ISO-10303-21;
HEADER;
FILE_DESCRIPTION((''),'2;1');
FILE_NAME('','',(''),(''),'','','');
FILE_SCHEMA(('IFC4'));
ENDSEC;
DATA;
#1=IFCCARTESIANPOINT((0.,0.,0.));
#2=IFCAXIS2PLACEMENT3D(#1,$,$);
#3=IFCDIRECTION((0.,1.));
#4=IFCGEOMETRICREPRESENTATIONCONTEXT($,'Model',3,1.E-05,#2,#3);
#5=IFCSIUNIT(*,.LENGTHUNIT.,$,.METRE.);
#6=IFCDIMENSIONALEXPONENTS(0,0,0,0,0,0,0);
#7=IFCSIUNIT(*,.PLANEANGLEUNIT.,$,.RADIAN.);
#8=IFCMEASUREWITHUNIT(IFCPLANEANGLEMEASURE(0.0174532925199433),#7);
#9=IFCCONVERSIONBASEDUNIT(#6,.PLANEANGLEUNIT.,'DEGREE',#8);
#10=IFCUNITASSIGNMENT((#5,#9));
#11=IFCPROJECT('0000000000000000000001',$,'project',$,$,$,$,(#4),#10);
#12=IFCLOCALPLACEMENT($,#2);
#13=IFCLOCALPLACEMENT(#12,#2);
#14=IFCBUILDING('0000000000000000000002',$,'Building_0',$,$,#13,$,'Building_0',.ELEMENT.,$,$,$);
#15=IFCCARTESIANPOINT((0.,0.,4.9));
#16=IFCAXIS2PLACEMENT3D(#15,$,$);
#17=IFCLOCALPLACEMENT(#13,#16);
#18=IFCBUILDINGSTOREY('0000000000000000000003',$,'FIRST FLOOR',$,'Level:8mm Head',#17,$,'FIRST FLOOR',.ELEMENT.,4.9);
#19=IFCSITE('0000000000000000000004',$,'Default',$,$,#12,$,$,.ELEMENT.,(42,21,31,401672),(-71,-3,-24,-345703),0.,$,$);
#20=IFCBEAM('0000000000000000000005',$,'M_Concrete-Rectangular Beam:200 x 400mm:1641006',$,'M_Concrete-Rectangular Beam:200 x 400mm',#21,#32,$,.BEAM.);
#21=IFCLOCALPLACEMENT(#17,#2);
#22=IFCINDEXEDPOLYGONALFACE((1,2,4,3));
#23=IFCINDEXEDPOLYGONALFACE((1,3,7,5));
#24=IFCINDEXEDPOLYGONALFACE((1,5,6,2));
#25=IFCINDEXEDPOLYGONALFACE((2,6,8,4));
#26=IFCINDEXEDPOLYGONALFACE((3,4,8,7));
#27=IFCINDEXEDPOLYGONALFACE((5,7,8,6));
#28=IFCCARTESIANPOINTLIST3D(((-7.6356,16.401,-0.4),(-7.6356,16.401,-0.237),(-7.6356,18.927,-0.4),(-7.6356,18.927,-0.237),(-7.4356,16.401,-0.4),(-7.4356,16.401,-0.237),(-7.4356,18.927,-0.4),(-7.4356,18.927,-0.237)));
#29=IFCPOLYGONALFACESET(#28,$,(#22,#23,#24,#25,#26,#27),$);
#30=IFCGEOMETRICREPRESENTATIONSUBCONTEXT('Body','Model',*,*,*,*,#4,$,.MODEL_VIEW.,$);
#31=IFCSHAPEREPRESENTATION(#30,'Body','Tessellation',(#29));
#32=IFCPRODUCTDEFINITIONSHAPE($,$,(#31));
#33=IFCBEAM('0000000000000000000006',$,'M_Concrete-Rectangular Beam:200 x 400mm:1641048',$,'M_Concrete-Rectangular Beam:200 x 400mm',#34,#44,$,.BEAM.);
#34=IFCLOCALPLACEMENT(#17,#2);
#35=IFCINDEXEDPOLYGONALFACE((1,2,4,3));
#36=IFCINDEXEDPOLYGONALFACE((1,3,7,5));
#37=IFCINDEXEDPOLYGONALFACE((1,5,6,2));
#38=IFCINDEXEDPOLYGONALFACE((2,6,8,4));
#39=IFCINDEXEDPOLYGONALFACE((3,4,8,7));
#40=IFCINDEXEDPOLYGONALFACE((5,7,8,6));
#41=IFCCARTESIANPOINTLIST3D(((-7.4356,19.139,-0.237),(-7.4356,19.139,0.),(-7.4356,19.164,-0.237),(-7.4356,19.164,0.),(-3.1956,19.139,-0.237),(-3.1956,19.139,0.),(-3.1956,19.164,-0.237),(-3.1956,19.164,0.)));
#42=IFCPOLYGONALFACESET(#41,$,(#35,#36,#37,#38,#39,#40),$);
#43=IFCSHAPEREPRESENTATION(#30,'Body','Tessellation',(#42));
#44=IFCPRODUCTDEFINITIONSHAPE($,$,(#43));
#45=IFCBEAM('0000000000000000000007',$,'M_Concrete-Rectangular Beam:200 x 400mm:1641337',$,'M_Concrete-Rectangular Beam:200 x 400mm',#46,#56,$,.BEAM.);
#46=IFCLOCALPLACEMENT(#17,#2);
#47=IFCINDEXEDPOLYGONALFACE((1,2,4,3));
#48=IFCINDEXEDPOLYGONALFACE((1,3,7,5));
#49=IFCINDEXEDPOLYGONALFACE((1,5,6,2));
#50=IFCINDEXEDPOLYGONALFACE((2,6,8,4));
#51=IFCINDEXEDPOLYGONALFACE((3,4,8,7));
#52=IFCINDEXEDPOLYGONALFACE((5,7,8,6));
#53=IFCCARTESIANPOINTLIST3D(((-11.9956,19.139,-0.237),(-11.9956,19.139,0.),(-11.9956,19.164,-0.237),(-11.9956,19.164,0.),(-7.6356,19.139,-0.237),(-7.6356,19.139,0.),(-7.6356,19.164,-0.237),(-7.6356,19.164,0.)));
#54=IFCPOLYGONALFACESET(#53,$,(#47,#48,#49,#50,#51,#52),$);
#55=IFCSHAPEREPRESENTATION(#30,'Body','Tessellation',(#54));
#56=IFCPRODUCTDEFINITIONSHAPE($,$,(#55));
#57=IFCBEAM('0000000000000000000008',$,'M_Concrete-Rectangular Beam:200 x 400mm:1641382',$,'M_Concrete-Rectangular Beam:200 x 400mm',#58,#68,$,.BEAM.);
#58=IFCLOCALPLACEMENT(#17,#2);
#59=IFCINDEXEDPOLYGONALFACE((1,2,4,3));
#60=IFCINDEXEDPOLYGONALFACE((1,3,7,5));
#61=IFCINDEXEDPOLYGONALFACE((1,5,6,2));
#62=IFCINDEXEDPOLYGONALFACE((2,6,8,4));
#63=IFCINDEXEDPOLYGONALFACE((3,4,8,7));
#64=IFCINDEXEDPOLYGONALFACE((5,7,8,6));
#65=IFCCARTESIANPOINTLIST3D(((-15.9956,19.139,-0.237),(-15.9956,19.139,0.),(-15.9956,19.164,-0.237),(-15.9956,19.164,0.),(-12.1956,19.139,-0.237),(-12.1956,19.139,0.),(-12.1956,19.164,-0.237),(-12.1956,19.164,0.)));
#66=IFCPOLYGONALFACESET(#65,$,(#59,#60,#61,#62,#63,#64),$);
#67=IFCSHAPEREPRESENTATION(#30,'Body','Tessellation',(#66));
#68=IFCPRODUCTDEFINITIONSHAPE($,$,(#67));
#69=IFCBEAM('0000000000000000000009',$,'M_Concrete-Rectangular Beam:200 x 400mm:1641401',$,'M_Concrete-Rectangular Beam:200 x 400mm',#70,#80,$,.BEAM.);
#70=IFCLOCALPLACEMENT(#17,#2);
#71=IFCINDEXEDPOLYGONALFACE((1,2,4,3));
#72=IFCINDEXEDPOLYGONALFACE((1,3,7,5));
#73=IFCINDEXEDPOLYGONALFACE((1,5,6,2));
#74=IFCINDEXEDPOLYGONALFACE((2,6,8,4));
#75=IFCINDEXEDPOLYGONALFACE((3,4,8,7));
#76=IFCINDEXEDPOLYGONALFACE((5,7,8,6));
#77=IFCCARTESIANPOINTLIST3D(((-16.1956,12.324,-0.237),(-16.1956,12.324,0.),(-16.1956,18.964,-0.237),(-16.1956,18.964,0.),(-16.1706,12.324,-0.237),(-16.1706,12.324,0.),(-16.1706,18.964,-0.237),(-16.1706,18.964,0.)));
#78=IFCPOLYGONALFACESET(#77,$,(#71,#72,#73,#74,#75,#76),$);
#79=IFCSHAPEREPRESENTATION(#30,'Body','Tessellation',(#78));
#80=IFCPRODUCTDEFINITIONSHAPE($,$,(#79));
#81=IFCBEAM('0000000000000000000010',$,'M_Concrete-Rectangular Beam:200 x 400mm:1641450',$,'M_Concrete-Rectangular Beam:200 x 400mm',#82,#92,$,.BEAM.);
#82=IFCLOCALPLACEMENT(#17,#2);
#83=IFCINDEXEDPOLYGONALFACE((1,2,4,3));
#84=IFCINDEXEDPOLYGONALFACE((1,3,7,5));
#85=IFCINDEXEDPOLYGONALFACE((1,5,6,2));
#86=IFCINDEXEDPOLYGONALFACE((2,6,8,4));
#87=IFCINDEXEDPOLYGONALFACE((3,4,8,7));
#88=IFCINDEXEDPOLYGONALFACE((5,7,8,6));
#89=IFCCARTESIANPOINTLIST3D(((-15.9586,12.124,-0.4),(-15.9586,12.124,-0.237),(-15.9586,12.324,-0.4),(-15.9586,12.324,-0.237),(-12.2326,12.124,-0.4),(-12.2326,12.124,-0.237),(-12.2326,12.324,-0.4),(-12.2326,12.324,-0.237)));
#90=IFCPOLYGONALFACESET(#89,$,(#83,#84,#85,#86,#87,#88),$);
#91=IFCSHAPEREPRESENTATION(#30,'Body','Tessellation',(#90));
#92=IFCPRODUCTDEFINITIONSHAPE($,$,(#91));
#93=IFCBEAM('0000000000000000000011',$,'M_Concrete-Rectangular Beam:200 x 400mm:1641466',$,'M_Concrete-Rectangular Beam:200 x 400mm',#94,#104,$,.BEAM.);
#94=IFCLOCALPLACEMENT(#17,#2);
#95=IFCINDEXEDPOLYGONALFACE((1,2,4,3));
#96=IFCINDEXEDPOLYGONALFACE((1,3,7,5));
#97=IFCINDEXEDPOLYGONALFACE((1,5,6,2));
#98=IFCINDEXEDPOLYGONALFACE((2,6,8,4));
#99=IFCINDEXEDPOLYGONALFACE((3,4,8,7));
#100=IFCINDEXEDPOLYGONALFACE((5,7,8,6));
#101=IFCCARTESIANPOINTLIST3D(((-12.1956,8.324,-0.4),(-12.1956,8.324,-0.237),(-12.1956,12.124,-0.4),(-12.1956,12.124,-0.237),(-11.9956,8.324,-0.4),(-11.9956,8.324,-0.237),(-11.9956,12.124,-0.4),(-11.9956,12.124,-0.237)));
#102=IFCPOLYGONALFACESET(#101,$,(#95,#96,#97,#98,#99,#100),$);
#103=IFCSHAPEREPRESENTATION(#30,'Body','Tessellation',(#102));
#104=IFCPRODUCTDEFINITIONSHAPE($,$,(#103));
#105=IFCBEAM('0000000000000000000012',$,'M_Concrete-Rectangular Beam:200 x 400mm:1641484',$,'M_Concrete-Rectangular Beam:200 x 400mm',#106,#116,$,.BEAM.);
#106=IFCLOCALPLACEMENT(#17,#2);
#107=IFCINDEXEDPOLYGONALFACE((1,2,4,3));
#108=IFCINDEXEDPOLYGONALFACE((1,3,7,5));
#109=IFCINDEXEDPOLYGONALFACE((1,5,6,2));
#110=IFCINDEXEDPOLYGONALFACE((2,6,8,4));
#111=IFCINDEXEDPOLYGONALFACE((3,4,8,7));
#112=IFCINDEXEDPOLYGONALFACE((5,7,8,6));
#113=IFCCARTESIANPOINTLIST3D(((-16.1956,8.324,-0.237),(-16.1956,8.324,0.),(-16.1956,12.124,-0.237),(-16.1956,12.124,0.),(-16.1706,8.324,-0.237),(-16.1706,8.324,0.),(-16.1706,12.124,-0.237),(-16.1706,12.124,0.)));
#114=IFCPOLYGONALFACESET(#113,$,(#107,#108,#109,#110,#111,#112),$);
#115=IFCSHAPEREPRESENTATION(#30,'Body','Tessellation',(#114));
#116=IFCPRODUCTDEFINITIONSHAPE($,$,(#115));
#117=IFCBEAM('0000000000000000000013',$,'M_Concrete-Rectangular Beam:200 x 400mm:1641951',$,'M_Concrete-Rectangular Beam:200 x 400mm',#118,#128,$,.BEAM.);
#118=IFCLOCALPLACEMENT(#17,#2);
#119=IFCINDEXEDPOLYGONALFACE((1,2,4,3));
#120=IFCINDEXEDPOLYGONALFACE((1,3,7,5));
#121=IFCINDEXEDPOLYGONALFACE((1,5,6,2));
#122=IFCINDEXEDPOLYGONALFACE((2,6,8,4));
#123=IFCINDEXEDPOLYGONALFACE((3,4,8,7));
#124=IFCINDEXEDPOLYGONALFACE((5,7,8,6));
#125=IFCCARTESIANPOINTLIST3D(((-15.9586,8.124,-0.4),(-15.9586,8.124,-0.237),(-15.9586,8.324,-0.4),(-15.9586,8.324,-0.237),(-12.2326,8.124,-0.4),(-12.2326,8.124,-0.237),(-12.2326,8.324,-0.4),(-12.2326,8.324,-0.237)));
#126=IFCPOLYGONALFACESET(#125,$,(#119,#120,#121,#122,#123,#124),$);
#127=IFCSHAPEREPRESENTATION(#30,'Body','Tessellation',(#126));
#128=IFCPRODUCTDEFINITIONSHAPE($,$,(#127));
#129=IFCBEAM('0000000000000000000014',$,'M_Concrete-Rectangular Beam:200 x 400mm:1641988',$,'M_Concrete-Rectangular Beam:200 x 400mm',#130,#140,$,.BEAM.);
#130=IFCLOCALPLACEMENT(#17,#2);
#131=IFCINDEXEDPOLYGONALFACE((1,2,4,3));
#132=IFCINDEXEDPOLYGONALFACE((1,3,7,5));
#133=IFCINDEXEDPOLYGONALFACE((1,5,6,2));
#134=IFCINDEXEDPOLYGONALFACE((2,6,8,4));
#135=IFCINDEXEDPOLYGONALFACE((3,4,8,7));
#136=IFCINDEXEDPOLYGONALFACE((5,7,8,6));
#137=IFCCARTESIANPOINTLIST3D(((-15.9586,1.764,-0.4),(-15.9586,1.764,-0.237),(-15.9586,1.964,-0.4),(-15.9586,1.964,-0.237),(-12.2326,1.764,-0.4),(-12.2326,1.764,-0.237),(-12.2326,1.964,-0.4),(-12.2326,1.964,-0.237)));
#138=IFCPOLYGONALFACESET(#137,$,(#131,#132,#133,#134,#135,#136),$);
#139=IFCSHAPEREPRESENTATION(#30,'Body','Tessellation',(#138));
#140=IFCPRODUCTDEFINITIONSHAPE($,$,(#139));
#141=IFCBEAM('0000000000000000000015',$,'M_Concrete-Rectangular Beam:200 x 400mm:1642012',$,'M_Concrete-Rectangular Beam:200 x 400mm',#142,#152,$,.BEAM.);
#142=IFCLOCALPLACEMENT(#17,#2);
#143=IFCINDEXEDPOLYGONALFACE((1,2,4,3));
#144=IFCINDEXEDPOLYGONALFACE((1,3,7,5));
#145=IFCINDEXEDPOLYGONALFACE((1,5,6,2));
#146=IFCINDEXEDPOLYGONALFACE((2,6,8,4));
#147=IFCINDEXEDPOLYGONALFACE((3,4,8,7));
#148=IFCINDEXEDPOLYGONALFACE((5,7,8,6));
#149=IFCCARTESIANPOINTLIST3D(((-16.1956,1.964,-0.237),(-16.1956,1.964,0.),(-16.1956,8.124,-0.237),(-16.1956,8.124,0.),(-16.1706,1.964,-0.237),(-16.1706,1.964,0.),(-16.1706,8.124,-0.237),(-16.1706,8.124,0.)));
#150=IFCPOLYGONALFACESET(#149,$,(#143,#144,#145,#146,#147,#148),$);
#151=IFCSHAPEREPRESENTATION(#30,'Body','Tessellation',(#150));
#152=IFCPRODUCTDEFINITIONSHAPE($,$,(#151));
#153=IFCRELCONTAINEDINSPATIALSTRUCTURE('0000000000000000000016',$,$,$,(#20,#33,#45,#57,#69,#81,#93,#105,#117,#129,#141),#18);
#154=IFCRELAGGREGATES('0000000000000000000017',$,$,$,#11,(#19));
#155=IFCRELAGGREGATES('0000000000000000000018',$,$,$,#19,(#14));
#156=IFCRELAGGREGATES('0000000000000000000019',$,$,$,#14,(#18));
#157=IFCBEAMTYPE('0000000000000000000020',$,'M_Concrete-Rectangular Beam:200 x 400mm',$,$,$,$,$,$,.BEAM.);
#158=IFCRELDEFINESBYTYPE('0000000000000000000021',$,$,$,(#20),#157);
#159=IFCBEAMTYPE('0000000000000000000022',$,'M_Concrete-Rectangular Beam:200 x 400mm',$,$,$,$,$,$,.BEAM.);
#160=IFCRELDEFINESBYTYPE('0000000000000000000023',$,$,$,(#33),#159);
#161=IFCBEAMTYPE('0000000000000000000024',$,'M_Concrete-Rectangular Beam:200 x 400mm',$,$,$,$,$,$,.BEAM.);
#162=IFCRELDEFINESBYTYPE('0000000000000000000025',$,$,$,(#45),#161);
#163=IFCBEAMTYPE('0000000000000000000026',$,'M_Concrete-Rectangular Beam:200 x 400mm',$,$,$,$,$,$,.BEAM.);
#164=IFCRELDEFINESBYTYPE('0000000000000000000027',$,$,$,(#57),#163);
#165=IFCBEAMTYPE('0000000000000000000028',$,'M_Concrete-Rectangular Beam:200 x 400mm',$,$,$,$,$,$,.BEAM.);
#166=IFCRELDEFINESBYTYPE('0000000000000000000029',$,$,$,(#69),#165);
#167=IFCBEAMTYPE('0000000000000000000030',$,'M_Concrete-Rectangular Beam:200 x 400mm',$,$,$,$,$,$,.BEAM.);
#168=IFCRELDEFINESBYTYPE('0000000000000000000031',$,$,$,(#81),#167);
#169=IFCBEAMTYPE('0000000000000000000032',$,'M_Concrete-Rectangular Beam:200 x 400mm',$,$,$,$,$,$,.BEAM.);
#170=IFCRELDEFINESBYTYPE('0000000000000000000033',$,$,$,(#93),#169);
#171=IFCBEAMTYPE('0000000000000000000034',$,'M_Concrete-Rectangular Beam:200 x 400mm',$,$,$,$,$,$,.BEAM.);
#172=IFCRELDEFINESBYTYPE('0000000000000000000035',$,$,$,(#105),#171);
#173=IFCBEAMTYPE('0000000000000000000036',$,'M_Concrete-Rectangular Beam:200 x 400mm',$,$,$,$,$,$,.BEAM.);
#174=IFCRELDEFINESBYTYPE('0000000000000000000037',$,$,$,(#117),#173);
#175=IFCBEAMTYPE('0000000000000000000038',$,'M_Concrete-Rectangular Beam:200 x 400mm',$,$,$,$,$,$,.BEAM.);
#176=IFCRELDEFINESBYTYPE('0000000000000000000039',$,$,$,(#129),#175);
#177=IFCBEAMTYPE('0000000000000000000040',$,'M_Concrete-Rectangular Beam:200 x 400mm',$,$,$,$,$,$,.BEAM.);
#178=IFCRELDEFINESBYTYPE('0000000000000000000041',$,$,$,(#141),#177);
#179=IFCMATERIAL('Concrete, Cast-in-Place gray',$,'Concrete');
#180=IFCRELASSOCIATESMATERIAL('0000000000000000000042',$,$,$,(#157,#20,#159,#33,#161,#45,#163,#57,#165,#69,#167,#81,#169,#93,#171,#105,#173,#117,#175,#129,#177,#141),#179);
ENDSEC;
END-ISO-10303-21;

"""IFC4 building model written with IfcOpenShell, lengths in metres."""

from ifc_helpers import new_model, entity, si_unit, converted_unit, direction, frame, origin, place, context, subcontext, project, spatial, indexed_curve, outline, extrude, source, transform, mapped, material, type_object, type_shapes, element, save


model = new_model("IFC4")

# Units and contexts
model_context = context("Model", 3, precision=1e-05, world=origin(), true_north=direction((0.0, 1.0)))
body_context = subcontext(model_context, "Body", "Model", "MODEL_VIEW")
ifc_project = project(units=[si_unit("LENGTHUNIT", "METRE"), converted_unit("PLANEANGLEUNIT", "DEGREE", entity("IfcPlaneAngleMeasure", 0.0174532925199433), si_unit("PLANEANGLEUNIT", "RADIAN"), dimensions=[0, 0, 0, 0, 0, 0, 0])], contexts=[model_context])

# Site, building, storey
site_placement = place(None, origin())
site = spatial("IfcSite", under=ifc_project, at=site_placement, Name="Default", CompositionType="ELEMENT", RefLatitude=(42, 21, 31, 401672), RefLongitude=(-71, -3, -24, -345703), RefElevation=0.0)
building_placement = place(site_placement, origin())
building = spatial("IfcBuilding", under=site, at=building_placement, Name="Building_0", LongName="Building_0", CompositionType="ELEMENT")
storey_placement = place(building_placement, frame((0.0, 0.0, 4.9)))
storey = spatial("IfcBuildingStorey", under=building, at=storey_placement, Name="FIRST FLOOR", ObjectType="Level:8mm Head", LongName="FIRST FLOOR", CompositionType="ELEMENT", Elevation=4.9)

# Beams
ifc_material = material(Name="Concrete, Cast-in-Place gray", Category="Concrete")
beam_type_1 = type_object("IfcBeamType", Name="M_Concrete-Rectangular Beam:200 x 400mm", PredefinedType="BEAM", material=ifc_material)
shared_shape_1 = source(origin(), body_context, "Body", "SweptSolid", [
    extrude(outline(indexed_curve([(-0.1, -0.0815), (0.1, -0.0815), (0.1, 0.0815), (-0.1, 0.0815), (-0.1, -0.0815)], self_intersect=False)), frame((-7.5356, 18.927, 4.5815), z_axis=(0.0, -1.0, 0.0), x_axis=(-1.0, 0.0, 0.0)), (0.0, 0.0, 1.0), 2.526),
])
type_shapes(beam_type_1, [shared_shape_1])
beam_1_placement = place(storey_placement, frame((0.0, 0.0, -4.9)))
element("IfcBeam", 1, at=beam_1_placement, inside=storey, type_object=beam_type_1, material=ifc_material, Name="M_Concrete-Rectangular Beam:200 x 400mm:1641006", ObjectType="M_Concrete-Rectangular Beam:200 x 400mm", PredefinedType="BEAM", context=body_context, shape_type="MappedRepresentation", body=[
    mapped(shared_shape_1, transform((0.0, 0.0, 0.0), scale=1.0)),
])
beam_type_2 = type_object("IfcBeamType", Name="M_Concrete-Rectangular Beam:200 x 400mm", PredefinedType="BEAM", material=ifc_material)
shared_shape_2 = source(origin(), body_context, "Body", "SweptSolid", [
    extrude(outline(indexed_curve([(-0.1185, -0.0125), (0.1185, -0.0125), (0.1185, 0.0125), (-0.1185, 0.0125), (-0.1185, -0.0125)], self_intersect=False)), frame((-7.4356, 19.1515, 4.7815), z_axis=(1.0, 0.0, 0.0), x_axis=(0.0, 0.0, -1.0)), (0.0, 0.0, 1.0), 4.24),
])
type_shapes(beam_type_2, [shared_shape_2])
beam_2_placement = place(storey_placement, frame((0.0, 0.0, -4.9)))
element("IfcBeam", 2, at=beam_2_placement, inside=storey, type_object=beam_type_2, material=ifc_material, Name="M_Concrete-Rectangular Beam:200 x 400mm:1641048", ObjectType="M_Concrete-Rectangular Beam:200 x 400mm", PredefinedType="BEAM", context=body_context, shape_type="MappedRepresentation", body=[
    mapped(shared_shape_2, transform((0.0, 0.0, 0.0), scale=1.0)),
])
beam_type_3 = type_object("IfcBeamType", Name="M_Concrete-Rectangular Beam:200 x 400mm", PredefinedType="BEAM", material=ifc_material)
shared_shape_3 = source(origin(), body_context, "Body", "SweptSolid", [
    extrude(outline(indexed_curve([(-0.1185, -0.0125), (0.1185, -0.0125), (0.1185, 0.0125), (-0.1185, 0.0125), (-0.1185, -0.0125)], self_intersect=False)), frame((-7.6356, 19.1515, 4.7815), z_axis=(-1.0, 0.0, 0.0), x_axis=(0.0, 0.0, -1.0)), (0.0, 0.0, 1.0), 4.36),
])
type_shapes(beam_type_3, [shared_shape_3])
beam_3_placement = place(storey_placement, frame((0.0, 0.0, -4.9)))
element("IfcBeam", 3, at=beam_3_placement, inside=storey, type_object=beam_type_3, material=ifc_material, Name="M_Concrete-Rectangular Beam:200 x 400mm:1641337", ObjectType="M_Concrete-Rectangular Beam:200 x 400mm", PredefinedType="BEAM", context=body_context, shape_type="MappedRepresentation", body=[
    mapped(shared_shape_3, transform((0.0, 0.0, 0.0), scale=1.0)),
])
beam_type_4 = type_object("IfcBeamType", Name="M_Concrete-Rectangular Beam:200 x 400mm", PredefinedType="BEAM", material=ifc_material)
shared_shape_4 = source(origin(), body_context, "Body", "SweptSolid", [
    extrude(outline(indexed_curve([(-0.1185, -0.0125), (0.1185, -0.0125), (0.1185, 0.0125), (-0.1185, 0.0125), (-0.1185, -0.0125)], self_intersect=False)), frame((-12.1956, 19.1515, 4.7815), z_axis=(-1.0, 0.0, 0.0), x_axis=(0.0, 0.0, -1.0)), (0.0, 0.0, 1.0), 3.8),
])
type_shapes(beam_type_4, [shared_shape_4])
beam_4_placement = place(storey_placement, frame((0.0, 0.0, -4.9)))
element("IfcBeam", 4, at=beam_4_placement, inside=storey, type_object=beam_type_4, material=ifc_material, Name="M_Concrete-Rectangular Beam:200 x 400mm:1641382", ObjectType="M_Concrete-Rectangular Beam:200 x 400mm", PredefinedType="BEAM", context=body_context, shape_type="MappedRepresentation", body=[
    mapped(shared_shape_4, transform((0.0, 0.0, 0.0), scale=1.0)),
])
beam_type_5 = type_object("IfcBeamType", Name="M_Concrete-Rectangular Beam:200 x 400mm", PredefinedType="BEAM", material=ifc_material)
shared_shape_5 = source(origin(), body_context, "Body", "SweptSolid", [
    extrude(outline(indexed_curve([(-0.0125, -0.1185), (0.0125, -0.1185), (0.0125, 0.1185), (-0.0125, 0.1185), (-0.0125, -0.1185)], self_intersect=False)), frame((-16.1831, 18.964, 4.7815), z_axis=(0.0, -1.0, 0.0), x_axis=(-1.0, 0.0, 0.0)), (0.0, 0.0, 1.0), 6.64),
])
type_shapes(beam_type_5, [shared_shape_5])
beam_5_placement = place(storey_placement, frame((0.0, 0.0, -4.9)))
element("IfcBeam", 5, at=beam_5_placement, inside=storey, type_object=beam_type_5, material=ifc_material, Name="M_Concrete-Rectangular Beam:200 x 400mm:1641401", ObjectType="M_Concrete-Rectangular Beam:200 x 400mm", PredefinedType="BEAM", context=body_context, shape_type="MappedRepresentation", body=[
    mapped(shared_shape_5, transform((0.0, 0.0, 0.0), scale=1.0)),
])
beam_type_6 = type_object("IfcBeamType", Name="M_Concrete-Rectangular Beam:200 x 400mm", PredefinedType="BEAM", material=ifc_material)
shared_shape_6 = source(origin(), body_context, "Body", "SweptSolid", [
    extrude(outline(indexed_curve([(-0.0815, -0.1), (0.0815, -0.1), (0.0815, 0.1), (-0.0815, 0.1), (-0.0815, -0.1)], self_intersect=False)), frame((-15.9586, 12.224, 4.5815), z_axis=(1.0, 0.0, 0.0), x_axis=(0.0, 0.0, -1.0)), (0.0, 0.0, 1.0), 3.726),
])
type_shapes(beam_type_6, [shared_shape_6])
beam_6_placement = place(storey_placement, frame((0.0, 0.0, -4.9)))
element("IfcBeam", 6, at=beam_6_placement, inside=storey, type_object=beam_type_6, material=ifc_material, Name="M_Concrete-Rectangular Beam:200 x 400mm:1641450", ObjectType="M_Concrete-Rectangular Beam:200 x 400mm", PredefinedType="BEAM", context=body_context, shape_type="MappedRepresentation", body=[
    mapped(shared_shape_6, transform((0.0, 0.0, 0.0), scale=1.0)),
])
beam_type_7 = type_object("IfcBeamType", Name="M_Concrete-Rectangular Beam:200 x 400mm", PredefinedType="BEAM", material=ifc_material)
shared_shape_7 = source(origin(), body_context, "Body", "SweptSolid", [
    extrude(outline(indexed_curve([(-0.1, -0.0815), (0.1, -0.0815), (0.1, 0.0815), (-0.1, 0.0815), (-0.1, -0.0815)], self_intersect=False)), frame((-12.0956, 12.124, 4.5815), z_axis=(0.0, -1.0, 0.0), x_axis=(-1.0, 0.0, 0.0)), (0.0, 0.0, 1.0), 3.8),
])
type_shapes(beam_type_7, [shared_shape_7])
beam_7_placement = place(storey_placement, frame((0.0, 0.0, -4.9)))
element("IfcBeam", 7, at=beam_7_placement, inside=storey, type_object=beam_type_7, material=ifc_material, Name="M_Concrete-Rectangular Beam:200 x 400mm:1641466", ObjectType="M_Concrete-Rectangular Beam:200 x 400mm", PredefinedType="BEAM", context=body_context, shape_type="MappedRepresentation", body=[
    mapped(shared_shape_7, transform((0.0, 0.0, 0.0), scale=1.0)),
])
beam_type_8 = type_object("IfcBeamType", Name="M_Concrete-Rectangular Beam:200 x 400mm", PredefinedType="BEAM", material=ifc_material)
shared_shape_8 = source(origin(), body_context, "Body", "SweptSolid", [
    extrude(outline(indexed_curve([(-0.0125, -0.1185), (0.0125, -0.1185), (0.0125, 0.1185), (-0.0125, 0.1185), (-0.0125, -0.1185)], self_intersect=False)), frame((-16.1831, 12.124, 4.7815), z_axis=(0.0, -1.0, 0.0), x_axis=(-1.0, 0.0, 0.0)), (0.0, 0.0, 1.0), 3.8),
])
type_shapes(beam_type_8, [shared_shape_8])
beam_8_placement = place(storey_placement, frame((0.0, 0.0, -4.9)))
element("IfcBeam", 8, at=beam_8_placement, inside=storey, type_object=beam_type_8, material=ifc_material, Name="M_Concrete-Rectangular Beam:200 x 400mm:1641484", ObjectType="M_Concrete-Rectangular Beam:200 x 400mm", PredefinedType="BEAM", context=body_context, shape_type="MappedRepresentation", body=[
    mapped(shared_shape_8, transform((0.0, 0.0, 0.0), scale=1.0)),
])
beam_type_9 = type_object("IfcBeamType", Name="M_Concrete-Rectangular Beam:200 x 400mm", PredefinedType="BEAM", material=ifc_material)
shared_shape_9 = source(origin(), body_context, "Body", "SweptSolid", [
    extrude(outline(indexed_curve([(-0.0815, -0.1), (0.0815, -0.1), (0.0815, 0.1), (-0.0815, 0.1), (-0.0815, -0.1)], self_intersect=False)), frame((-15.9586, 8.224, 4.5815), z_axis=(1.0, 0.0, 0.0), x_axis=(0.0, 0.0, -1.0)), (0.0, 0.0, 1.0), 3.726),
])
type_shapes(beam_type_9, [shared_shape_9])
beam_9_placement = place(storey_placement, frame((0.0, 0.0, -4.9)))
element("IfcBeam", 9, at=beam_9_placement, inside=storey, type_object=beam_type_9, material=ifc_material, Name="M_Concrete-Rectangular Beam:200 x 400mm:1641951", ObjectType="M_Concrete-Rectangular Beam:200 x 400mm", PredefinedType="BEAM", context=body_context, shape_type="MappedRepresentation", body=[
    mapped(shared_shape_9, transform((0.0, 0.0, 0.0), scale=1.0)),
])
beam_type_10 = type_object("IfcBeamType", Name="M_Concrete-Rectangular Beam:200 x 400mm", PredefinedType="BEAM", material=ifc_material)
shared_shape_10 = source(origin(), body_context, "Body", "SweptSolid", [
    extrude(outline(indexed_curve([(-0.0815, -0.1), (0.0815, -0.1), (0.0815, 0.1), (-0.0815, 0.1), (-0.0815, -0.1)], self_intersect=False)), frame((-12.2326, 1.864, 4.5815), z_axis=(-1.0, 0.0, 0.0), x_axis=(0.0, 0.0, -1.0)), (0.0, 0.0, 1.0), 3.726),
])
type_shapes(beam_type_10, [shared_shape_10])
beam_10_placement = place(storey_placement, frame((0.0, 0.0, -4.9)))
element("IfcBeam", 10, at=beam_10_placement, inside=storey, type_object=beam_type_10, material=ifc_material, Name="M_Concrete-Rectangular Beam:200 x 400mm:1641988", ObjectType="M_Concrete-Rectangular Beam:200 x 400mm", PredefinedType="BEAM", context=body_context, shape_type="MappedRepresentation", body=[
    mapped(shared_shape_10, transform((0.0, 0.0, 0.0), scale=1.0)),
])
beam_type_11 = type_object("IfcBeamType", Name="M_Concrete-Rectangular Beam:200 x 400mm", PredefinedType="BEAM", material=ifc_material)
shared_shape_11 = source(origin(), body_context, "Body", "SweptSolid", [
    extrude(outline(indexed_curve([(-0.0125, -0.1185), (0.0125, -0.1185), (0.0125, 0.1185), (-0.0125, 0.1185), (-0.0125, -0.1185)], self_intersect=False)), frame((-16.1831, 8.124, 4.7815), z_axis=(0.0, -1.0, 0.0), x_axis=(-1.0, 0.0, 0.0)), (0.0, 0.0, 1.0), 6.16),
])
type_shapes(beam_type_11, [shared_shape_11])
beam_11_placement = place(storey_placement, frame((0.0, 0.0, -4.9)))
element("IfcBeam", 11, at=beam_11_placement, inside=storey, type_object=beam_type_11, material=ifc_material, Name="M_Concrete-Rectangular Beam:200 x 400mm:1642012", ObjectType="M_Concrete-Rectangular Beam:200 x 400mm", PredefinedType="BEAM", context=body_context, shape_type="MappedRepresentation", body=[
    mapped(shared_shape_11, transform((0.0, 0.0, 0.0), scale=1.0)),
])

save(model, "model.ifc")
